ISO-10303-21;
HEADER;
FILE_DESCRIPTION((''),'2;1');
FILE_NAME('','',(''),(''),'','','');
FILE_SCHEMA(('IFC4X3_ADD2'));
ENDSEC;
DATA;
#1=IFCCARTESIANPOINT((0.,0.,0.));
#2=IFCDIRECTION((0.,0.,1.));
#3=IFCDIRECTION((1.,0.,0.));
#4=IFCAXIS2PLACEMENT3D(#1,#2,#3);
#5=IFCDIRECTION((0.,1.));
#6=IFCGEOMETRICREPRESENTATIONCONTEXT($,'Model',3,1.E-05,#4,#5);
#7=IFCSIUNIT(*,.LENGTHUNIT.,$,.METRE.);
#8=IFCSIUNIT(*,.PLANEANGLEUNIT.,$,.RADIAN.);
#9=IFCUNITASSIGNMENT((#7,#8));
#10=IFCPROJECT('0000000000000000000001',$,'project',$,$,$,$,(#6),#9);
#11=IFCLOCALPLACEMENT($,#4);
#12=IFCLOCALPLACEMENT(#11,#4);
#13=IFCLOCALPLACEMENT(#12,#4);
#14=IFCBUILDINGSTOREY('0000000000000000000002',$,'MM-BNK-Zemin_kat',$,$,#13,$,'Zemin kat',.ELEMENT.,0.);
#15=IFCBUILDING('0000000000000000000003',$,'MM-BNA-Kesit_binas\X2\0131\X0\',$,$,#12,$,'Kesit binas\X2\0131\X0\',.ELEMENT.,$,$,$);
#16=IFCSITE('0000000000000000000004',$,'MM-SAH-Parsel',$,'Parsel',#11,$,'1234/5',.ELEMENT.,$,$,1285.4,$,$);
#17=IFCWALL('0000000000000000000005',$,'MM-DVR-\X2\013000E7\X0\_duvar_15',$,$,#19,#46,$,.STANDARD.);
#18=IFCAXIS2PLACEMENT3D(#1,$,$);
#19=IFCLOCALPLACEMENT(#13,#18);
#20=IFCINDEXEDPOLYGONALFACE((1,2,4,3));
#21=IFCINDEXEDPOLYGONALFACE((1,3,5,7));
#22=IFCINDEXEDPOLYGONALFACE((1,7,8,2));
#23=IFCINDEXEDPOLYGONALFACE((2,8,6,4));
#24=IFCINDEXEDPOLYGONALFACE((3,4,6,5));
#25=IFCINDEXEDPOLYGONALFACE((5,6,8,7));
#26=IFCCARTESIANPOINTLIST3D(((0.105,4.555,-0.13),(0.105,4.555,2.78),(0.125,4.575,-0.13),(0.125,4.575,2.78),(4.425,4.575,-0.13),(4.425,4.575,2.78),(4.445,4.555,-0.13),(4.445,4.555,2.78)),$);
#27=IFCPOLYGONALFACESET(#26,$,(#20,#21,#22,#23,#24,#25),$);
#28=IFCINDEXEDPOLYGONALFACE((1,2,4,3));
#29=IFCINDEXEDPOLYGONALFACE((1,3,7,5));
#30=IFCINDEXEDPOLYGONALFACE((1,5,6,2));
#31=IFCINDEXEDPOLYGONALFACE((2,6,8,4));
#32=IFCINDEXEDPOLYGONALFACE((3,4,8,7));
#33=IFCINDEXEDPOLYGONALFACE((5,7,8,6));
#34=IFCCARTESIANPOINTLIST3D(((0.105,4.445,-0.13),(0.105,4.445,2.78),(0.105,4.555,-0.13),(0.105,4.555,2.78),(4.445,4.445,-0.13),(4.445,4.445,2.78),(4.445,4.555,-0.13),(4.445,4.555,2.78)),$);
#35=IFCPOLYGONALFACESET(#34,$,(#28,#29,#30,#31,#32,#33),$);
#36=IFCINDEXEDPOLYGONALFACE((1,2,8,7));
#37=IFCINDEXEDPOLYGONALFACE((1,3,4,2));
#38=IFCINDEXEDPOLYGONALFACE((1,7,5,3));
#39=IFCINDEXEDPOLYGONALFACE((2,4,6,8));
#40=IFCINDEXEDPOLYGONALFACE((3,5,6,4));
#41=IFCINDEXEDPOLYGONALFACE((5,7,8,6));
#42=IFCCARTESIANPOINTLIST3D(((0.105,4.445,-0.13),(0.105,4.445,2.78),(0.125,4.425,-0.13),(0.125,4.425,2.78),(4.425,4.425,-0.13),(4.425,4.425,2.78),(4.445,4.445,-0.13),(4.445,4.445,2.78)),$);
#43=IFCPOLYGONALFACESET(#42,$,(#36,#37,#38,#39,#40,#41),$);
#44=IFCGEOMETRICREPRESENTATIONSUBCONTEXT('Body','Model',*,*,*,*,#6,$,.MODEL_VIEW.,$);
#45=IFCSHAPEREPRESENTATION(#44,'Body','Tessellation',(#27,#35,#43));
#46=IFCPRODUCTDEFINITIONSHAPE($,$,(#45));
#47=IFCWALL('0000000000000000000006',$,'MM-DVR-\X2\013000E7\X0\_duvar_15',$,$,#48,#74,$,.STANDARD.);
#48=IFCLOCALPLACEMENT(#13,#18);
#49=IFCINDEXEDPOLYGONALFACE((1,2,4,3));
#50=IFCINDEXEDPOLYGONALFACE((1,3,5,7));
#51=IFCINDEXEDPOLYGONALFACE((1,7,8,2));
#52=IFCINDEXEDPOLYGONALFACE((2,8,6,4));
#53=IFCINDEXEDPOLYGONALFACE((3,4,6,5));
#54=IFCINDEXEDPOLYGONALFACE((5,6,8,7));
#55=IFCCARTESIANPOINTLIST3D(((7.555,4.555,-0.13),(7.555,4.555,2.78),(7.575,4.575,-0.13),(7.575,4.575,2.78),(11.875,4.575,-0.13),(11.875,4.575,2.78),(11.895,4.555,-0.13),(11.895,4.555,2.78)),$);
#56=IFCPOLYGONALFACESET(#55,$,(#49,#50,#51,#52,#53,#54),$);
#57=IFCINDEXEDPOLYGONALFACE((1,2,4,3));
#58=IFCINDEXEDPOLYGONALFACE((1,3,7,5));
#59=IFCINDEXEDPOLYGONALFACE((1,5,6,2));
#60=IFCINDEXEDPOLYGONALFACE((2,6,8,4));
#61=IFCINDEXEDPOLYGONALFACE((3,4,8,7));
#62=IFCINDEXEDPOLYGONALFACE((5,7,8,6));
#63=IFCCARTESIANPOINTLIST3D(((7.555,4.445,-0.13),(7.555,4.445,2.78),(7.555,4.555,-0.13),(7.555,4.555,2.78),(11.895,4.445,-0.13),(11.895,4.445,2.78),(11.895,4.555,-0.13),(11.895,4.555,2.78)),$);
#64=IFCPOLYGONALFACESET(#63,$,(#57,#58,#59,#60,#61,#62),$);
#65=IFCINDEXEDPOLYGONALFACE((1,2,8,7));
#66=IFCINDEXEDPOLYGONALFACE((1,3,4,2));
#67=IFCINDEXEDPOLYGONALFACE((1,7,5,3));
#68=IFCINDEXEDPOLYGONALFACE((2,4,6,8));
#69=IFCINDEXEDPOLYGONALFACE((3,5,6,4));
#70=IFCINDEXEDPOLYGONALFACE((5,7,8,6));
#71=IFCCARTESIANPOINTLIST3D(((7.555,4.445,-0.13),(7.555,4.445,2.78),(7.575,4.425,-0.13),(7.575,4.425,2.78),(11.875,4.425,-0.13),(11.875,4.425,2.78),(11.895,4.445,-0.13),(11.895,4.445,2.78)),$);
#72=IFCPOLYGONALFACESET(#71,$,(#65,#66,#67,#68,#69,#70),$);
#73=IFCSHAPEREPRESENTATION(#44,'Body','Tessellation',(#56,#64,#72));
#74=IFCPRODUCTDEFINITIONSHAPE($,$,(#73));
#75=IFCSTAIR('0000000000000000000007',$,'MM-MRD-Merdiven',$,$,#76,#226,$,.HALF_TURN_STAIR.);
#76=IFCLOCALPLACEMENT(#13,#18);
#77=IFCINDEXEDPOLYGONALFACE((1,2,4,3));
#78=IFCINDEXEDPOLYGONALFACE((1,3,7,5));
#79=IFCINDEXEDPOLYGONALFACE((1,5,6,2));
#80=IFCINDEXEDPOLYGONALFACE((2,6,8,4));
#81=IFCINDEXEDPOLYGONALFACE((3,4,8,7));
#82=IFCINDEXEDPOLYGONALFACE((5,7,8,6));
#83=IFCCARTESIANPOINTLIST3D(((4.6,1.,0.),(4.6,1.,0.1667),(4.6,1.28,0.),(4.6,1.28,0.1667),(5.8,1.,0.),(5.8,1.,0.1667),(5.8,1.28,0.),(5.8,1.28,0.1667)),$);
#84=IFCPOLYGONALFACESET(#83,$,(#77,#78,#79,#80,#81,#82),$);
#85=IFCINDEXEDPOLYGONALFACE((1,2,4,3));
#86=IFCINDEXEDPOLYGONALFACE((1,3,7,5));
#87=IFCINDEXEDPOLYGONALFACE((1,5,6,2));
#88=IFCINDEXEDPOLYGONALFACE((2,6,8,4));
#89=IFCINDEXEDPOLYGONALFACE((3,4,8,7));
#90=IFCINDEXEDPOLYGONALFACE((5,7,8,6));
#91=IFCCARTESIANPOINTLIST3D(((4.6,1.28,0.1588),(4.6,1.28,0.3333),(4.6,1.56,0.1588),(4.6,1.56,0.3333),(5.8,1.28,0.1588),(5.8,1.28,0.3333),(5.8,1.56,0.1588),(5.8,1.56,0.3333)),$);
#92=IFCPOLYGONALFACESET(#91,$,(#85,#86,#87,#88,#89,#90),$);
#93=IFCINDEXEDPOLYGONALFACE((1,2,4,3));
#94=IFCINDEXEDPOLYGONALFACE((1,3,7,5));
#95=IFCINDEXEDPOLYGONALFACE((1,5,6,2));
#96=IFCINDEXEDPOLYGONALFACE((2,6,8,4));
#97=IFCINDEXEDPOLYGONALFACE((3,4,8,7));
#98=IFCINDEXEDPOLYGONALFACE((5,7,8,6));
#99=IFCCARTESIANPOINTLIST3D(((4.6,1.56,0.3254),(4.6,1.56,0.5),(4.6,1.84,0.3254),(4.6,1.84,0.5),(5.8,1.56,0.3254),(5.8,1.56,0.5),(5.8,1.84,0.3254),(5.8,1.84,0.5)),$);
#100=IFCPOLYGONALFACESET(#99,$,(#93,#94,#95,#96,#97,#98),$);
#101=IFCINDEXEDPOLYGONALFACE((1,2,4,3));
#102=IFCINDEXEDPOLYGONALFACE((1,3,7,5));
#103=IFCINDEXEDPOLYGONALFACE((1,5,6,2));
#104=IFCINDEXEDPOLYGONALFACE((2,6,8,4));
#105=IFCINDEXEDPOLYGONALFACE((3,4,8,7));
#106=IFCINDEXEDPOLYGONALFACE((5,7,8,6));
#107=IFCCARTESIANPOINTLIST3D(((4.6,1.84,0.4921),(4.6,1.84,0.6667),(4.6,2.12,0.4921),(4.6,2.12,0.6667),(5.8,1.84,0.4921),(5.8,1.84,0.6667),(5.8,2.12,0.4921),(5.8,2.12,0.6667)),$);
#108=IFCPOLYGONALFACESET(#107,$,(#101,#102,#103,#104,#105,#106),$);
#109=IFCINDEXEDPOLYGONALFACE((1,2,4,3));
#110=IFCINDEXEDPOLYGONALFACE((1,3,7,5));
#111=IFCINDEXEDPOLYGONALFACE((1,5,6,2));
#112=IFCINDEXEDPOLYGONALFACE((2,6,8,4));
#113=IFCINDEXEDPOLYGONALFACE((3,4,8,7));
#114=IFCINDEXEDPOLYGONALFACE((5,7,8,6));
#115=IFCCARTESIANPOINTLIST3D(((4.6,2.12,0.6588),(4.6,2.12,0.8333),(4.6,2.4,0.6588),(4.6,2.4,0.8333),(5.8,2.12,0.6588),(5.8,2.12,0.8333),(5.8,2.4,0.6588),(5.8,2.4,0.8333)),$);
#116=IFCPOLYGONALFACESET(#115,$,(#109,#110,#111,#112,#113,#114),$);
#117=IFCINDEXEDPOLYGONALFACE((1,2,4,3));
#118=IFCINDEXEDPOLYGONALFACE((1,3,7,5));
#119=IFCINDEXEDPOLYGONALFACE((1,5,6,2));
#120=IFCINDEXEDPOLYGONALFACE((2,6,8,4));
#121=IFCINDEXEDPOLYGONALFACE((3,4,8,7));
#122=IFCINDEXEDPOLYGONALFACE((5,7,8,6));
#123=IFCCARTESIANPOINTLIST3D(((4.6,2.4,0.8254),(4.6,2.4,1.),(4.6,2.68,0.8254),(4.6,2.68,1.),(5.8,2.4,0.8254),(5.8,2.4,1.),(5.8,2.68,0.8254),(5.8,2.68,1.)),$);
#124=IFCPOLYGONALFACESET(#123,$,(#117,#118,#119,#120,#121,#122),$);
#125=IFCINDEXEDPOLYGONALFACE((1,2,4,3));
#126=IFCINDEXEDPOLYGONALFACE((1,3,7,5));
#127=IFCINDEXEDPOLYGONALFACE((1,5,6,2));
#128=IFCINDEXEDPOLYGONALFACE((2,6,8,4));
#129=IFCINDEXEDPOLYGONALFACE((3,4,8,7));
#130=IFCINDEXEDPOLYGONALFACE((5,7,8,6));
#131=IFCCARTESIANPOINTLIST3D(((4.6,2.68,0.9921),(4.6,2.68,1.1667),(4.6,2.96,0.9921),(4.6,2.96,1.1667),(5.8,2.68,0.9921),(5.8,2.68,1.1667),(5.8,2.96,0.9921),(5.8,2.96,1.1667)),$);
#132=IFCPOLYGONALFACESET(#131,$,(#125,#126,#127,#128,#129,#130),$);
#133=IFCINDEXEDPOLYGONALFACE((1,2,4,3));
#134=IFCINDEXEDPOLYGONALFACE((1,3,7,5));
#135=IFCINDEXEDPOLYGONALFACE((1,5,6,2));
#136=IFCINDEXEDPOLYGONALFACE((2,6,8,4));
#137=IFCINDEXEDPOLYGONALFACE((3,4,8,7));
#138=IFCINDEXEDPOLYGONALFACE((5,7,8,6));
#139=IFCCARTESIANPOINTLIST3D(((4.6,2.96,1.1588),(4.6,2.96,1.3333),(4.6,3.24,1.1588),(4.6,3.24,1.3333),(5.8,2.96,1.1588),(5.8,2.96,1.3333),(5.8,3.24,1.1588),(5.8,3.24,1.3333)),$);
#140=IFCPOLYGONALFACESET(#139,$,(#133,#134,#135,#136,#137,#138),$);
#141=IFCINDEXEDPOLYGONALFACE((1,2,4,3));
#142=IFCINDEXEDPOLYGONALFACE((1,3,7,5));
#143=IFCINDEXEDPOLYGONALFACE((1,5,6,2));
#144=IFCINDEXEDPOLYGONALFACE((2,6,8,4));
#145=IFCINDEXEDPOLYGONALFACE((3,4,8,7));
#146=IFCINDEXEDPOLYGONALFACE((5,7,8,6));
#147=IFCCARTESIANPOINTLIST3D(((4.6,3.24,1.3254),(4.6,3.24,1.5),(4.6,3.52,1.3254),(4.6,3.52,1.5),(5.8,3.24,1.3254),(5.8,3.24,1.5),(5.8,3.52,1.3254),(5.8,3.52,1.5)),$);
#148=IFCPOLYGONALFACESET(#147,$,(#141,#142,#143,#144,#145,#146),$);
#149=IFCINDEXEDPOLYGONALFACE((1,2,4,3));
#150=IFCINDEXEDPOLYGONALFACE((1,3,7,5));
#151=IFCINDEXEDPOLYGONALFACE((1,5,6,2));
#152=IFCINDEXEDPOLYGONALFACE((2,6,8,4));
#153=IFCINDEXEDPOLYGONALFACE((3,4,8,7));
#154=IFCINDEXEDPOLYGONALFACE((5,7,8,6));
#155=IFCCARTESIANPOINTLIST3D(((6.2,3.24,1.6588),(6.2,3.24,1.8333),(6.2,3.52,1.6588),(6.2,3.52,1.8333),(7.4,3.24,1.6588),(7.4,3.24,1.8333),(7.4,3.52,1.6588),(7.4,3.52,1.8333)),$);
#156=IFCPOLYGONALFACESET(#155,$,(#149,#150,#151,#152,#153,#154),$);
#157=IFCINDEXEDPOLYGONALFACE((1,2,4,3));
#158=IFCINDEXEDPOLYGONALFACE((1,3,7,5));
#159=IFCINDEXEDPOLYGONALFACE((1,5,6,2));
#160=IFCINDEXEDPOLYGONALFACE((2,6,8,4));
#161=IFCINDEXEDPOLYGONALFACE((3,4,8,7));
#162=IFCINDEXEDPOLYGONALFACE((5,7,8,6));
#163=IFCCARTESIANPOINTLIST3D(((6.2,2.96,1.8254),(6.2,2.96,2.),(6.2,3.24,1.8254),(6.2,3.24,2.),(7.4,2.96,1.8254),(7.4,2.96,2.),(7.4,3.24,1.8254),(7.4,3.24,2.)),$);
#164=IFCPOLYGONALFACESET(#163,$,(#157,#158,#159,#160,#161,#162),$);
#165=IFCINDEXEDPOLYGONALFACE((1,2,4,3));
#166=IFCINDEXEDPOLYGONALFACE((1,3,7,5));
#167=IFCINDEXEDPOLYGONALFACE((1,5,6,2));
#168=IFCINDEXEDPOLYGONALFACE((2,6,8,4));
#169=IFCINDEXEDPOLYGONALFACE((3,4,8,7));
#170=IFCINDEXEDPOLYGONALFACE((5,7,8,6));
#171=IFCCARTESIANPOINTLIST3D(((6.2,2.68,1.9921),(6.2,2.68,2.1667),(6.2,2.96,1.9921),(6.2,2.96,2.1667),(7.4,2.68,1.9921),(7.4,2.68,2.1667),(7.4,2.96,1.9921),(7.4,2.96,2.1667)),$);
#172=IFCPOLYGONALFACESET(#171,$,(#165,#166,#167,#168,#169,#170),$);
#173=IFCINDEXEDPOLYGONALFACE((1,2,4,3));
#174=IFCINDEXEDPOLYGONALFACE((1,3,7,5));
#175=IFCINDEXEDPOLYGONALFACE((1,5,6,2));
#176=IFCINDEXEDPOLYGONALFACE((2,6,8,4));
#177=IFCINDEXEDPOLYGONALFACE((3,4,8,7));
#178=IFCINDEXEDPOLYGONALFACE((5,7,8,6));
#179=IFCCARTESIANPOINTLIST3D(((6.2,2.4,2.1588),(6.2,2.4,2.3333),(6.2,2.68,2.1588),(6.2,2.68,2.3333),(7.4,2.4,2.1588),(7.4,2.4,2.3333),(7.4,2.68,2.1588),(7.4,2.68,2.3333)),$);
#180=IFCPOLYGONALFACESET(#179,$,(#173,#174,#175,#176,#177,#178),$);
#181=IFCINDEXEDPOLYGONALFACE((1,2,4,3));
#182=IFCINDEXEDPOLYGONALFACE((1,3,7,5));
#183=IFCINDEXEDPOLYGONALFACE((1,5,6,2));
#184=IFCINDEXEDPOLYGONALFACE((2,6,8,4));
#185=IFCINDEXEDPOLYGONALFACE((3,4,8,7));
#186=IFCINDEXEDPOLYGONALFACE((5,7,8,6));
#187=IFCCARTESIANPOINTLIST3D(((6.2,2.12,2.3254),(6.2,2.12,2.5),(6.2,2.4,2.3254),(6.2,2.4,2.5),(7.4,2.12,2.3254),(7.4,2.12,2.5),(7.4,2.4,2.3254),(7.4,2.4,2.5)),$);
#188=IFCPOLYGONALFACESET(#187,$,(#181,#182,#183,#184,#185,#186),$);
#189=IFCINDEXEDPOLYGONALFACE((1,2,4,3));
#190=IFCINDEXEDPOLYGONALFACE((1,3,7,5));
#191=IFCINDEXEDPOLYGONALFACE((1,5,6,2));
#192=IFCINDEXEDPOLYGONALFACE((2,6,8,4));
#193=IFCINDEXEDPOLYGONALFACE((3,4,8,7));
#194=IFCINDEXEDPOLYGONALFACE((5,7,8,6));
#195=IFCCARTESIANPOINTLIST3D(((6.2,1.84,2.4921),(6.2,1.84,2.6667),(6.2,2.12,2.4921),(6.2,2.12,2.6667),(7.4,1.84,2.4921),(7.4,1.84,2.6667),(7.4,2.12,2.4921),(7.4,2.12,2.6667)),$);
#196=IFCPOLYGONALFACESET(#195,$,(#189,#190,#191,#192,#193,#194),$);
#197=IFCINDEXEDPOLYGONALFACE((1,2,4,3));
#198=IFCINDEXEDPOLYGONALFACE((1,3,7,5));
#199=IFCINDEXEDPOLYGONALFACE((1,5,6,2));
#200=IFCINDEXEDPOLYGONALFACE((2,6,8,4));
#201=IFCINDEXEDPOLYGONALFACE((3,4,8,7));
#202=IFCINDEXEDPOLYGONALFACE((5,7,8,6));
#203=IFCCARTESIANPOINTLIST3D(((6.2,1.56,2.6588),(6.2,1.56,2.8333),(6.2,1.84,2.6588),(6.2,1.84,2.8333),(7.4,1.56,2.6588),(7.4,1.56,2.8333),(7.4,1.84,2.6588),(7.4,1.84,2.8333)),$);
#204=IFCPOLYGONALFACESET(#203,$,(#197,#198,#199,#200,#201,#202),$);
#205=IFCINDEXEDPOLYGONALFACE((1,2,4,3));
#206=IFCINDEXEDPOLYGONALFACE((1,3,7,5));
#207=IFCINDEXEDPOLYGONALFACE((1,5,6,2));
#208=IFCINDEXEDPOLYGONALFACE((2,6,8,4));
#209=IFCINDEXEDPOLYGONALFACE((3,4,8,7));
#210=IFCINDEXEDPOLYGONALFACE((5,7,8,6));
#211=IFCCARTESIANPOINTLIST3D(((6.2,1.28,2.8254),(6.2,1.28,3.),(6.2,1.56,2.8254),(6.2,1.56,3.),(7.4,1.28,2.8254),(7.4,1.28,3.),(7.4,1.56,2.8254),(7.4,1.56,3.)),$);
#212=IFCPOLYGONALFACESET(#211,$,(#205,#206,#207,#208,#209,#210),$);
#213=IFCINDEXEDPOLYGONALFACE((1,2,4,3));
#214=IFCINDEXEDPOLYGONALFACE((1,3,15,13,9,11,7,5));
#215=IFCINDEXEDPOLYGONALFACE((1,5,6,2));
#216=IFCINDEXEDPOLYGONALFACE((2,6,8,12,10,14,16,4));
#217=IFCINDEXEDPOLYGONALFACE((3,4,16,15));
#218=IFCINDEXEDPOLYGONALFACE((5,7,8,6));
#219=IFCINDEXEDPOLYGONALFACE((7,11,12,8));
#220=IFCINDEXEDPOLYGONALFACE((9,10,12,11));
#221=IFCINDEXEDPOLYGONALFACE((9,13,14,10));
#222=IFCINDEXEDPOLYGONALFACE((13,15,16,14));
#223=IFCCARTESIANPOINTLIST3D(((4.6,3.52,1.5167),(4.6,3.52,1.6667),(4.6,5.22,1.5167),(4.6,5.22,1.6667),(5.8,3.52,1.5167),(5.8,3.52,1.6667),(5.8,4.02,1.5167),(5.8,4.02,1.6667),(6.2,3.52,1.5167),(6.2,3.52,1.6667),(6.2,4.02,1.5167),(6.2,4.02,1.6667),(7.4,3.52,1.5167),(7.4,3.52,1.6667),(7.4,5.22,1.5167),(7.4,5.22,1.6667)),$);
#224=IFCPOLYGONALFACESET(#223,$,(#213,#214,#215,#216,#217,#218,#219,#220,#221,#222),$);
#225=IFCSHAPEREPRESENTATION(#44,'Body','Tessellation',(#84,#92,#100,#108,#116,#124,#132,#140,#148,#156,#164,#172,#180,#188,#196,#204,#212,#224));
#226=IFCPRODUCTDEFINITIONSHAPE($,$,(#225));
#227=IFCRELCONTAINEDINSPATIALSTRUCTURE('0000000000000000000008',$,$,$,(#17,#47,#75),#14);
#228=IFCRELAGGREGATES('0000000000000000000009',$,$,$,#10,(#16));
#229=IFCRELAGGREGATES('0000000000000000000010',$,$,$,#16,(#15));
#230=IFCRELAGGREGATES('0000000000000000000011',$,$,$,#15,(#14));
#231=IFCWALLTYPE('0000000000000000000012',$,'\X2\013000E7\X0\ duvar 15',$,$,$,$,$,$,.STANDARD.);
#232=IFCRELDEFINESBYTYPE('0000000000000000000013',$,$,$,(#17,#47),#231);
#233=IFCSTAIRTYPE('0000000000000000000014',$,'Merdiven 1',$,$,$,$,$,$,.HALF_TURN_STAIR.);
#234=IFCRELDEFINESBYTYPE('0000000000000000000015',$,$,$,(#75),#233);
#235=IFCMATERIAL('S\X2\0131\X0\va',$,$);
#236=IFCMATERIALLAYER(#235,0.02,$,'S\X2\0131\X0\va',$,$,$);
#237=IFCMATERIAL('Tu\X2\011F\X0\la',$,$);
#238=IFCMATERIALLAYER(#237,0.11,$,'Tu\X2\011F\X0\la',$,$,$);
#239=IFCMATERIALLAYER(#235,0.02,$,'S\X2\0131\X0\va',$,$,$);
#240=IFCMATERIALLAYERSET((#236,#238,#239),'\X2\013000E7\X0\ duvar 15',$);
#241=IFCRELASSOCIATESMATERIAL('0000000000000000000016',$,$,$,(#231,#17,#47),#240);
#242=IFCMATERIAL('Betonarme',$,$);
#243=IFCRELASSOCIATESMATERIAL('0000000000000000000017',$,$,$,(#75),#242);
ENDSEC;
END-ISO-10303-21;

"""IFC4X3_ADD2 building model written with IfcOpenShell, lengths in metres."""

from ifc_helpers import new_model, si_unit, direction, frame, origin, origin_with_axes, place, context, subcontext, project, spatial, polyline, outline, extrude, material, layer, layer_set, type_object, element, save


model = new_model("IFC4X3_ADD2")

# Units and contexts
model_context = context("Model", 3, precision=1e-05, world=origin_with_axes(), true_north=direction((0.0, 1.0)))
body_context = subcontext(model_context, "Body", "Model", "MODEL_VIEW")
ifc_project = project(units=[si_unit("LENGTHUNIT", "METRE"), si_unit("PLANEANGLEUNIT", "RADIAN")], contexts=[model_context])

# Site, building, storey
site_placement = place(None, origin_with_axes())
site = spatial("IfcSite", under=ifc_project, at=site_placement, Name="MM-SAH-Parsel", ObjectType="Parsel", LongName="1234/5", CompositionType="ELEMENT", RefElevation=1285.4)
building_placement = place(site_placement, origin_with_axes())
building = spatial("IfcBuilding", under=site, at=building_placement, Name="MM-BNA-Kesit_binası", LongName="Kesit binası", CompositionType="ELEMENT")
storey_placement = place(building_placement, origin_with_axes())
storey = spatial("IfcBuildingStorey", under=building, at=storey_placement, Name="MM-BNK-Zemin_kat", LongName="Zemin kat", CompositionType="ELEMENT", Elevation=0.0)

# Shared definitions
ifc_material_1 = material(Name="Betonarme")

# Shared definitions
ifc_material_2 = material(Name="Tuğla")

# Shared definitions
ifc_material_3 = material(Name="Sıva")
ifc_layer_1 = layer(ifc_material_3, 0.02, Name="Sıva")
ifc_layer_2 = layer(ifc_material_2, 0.11, Name="Tuğla")
ifc_layer_3 = layer(ifc_material_3, 0.02, Name="Sıva")
ifc_layer_set_1 = layer_set([ifc_layer_1, ifc_layer_2, ifc_layer_3], Name="İç duvar 15")
wall_type_1 = type_object("IfcWallType", Name="İç duvar 15", PredefinedType="STANDARD", material=ifc_layer_set_1)

# Walls
wall_1_placement = place(storey_placement, origin_with_axes())
element("IfcWall", 1, at=wall_1_placement, inside=storey, type_object=wall_type_1, material=ifc_layer_set_1, Name="MM-DVR-İç_duvar_15", PredefinedType="STANDARD", context=body_context, shape_type="SweptSolid", body=[
    extrude(outline(polyline([(0.125, 4.575), (4.425, 4.575), (4.445, 4.555), (0.105, 4.555), (0.125, 4.575)])), frame((0.0, 0.0, -0.13)), (0.0, 0.0, 1.0), 2.91),
    extrude(outline(polyline([(0.105, 4.555), (4.445, 4.555), (4.445, 4.445), (0.105, 4.445), (0.105, 4.555)])), frame((0.0, 0.0, -0.13)), (0.0, 0.0, 1.0), 2.91),
    extrude(outline(polyline([(0.105, 4.445), (4.445, 4.445), (4.425, 4.425), (0.125, 4.425), (0.105, 4.445)])), frame((0.0, 0.0, -0.13)), (0.0, 0.0, 1.0), 2.91),
])
wall_2_placement = place(storey_placement, origin_with_axes())
element("IfcWall", 2, at=wall_2_placement, inside=storey, type_object=wall_type_1, material=ifc_layer_set_1, Name="MM-DVR-İç_duvar_15", PredefinedType="STANDARD", context=body_context, shape_type="SweptSolid", body=[
    extrude(outline(polyline([(7.575, 4.575), (11.875, 4.575), (11.895, 4.555), (7.555, 4.555), (7.575, 4.575)])), frame((0.0, 0.0, -0.13)), (0.0, 0.0, 1.0), 2.91),
    extrude(outline(polyline([(7.555, 4.555), (11.895, 4.555), (11.895, 4.445), (7.555, 4.445), (7.555, 4.555)])), frame((0.0, 0.0, -0.13)), (0.0, 0.0, 1.0), 2.91),
    extrude(outline(polyline([(7.555, 4.445), (11.895, 4.445), (11.875, 4.425), (7.575, 4.425), (7.555, 4.445)])), frame((0.0, 0.0, -0.13)), (0.0, 0.0, 1.0), 2.91),
])

# Stair
stair_type = type_object("IfcStairType", Name="Merdiven 1", PredefinedType="HALF_TURN_STAIR")
stair_placement = place(storey_placement, origin_with_axes())
element("IfcStair", 3, at=stair_placement, inside=storey, type_object=stair_type, material=ifc_material_1, Name="MM-MRD-Merdiven", PredefinedType="HALF_TURN_STAIR", context=body_context, shape_type="SweptSolid", body=[
    extrude(outline(polyline([(5.8, 1.0), (5.8, 1.28), (4.6, 1.28), (4.6, 1.0), (5.8, 1.0)])), origin(), (0.0, 0.0, 1.0), 0.1667),
    extrude(outline(polyline([(5.8, 1.28), (5.8, 1.56), (4.6, 1.56), (4.6, 1.28), (5.8, 1.28)])), frame((0.0, 0.0, 0.1588)), (0.0, 0.0, 1.0), 0.1746),
    extrude(outline(polyline([(5.8, 1.56), (5.8, 1.84), (4.6, 1.84), (4.6, 1.56), (5.8, 1.56)])), frame((0.0, 0.0, 0.3254)), (0.0, 0.0, 1.0), 0.1746),
    extrude(outline(polyline([(5.8, 1.84), (5.8, 2.12), (4.6, 2.12), (4.6, 1.84), (5.8, 1.84)])), frame((0.0, 0.0, 0.4921)), (0.0, 0.0, 1.0), 0.1746),
    extrude(outline(polyline([(5.8, 2.12), (5.8, 2.4), (4.6, 2.4), (4.6, 2.12), (5.8, 2.12)])), frame((0.0, 0.0, 0.6588)), (0.0, 0.0, 1.0), 0.1746),
    extrude(outline(polyline([(5.8, 2.4), (5.8, 2.68), (4.6, 2.68), (4.6, 2.4), (5.8, 2.4)])), frame((0.0, 0.0, 0.8254)), (0.0, 0.0, 1.0), 0.1746),
    extrude(outline(polyline([(5.8, 2.68), (5.8, 2.96), (4.6, 2.96), (4.6, 2.68), (5.8, 2.68)])), frame((0.0, 0.0, 0.9921)), (0.0, 0.0, 1.0), 0.1746),
    extrude(outline(polyline([(5.8, 2.96), (5.8, 3.24), (4.6, 3.24), (4.6, 2.96), (5.8, 2.96)])), frame((0.0, 0.0, 1.1588)), (0.0, 0.0, 1.0), 0.1746),
    extrude(outline(polyline([(5.8, 3.24), (5.8, 3.52), (4.6, 3.52), (4.6, 3.24), (5.8, 3.24)])), frame((0.0, 0.0, 1.3254)), (0.0, 0.0, 1.0), 0.1746),
    extrude(outline(polyline([(6.2, 3.52), (6.2, 3.24), (7.4, 3.24), (7.4, 3.52), (6.2, 3.52)])), frame((0.0, 0.0, 1.6588)), (0.0, 0.0, 1.0), 0.1746),
    extrude(outline(polyline([(6.2, 3.24), (6.2, 2.96), (7.4, 2.96), (7.4, 3.24), (6.2, 3.24)])), frame((0.0, 0.0, 1.8254)), (0.0, 0.0, 1.0), 0.1746),
    extrude(outline(polyline([(6.2, 2.96), (6.2, 2.68), (7.4, 2.68), (7.4, 2.96), (6.2, 2.96)])), frame((0.0, 0.0, 1.9921)), (0.0, 0.0, 1.0), 0.1746),
    extrude(outline(polyline([(6.2, 2.68), (6.2, 2.4), (7.4, 2.4), (7.4, 2.68), (6.2, 2.68)])), frame((0.0, 0.0, 2.1588)), (0.0, 0.0, 1.0), 0.1746),
    extrude(outline(polyline([(6.2, 2.4), (6.2, 2.12), (7.4, 2.12), (7.4, 2.4), (6.2, 2.4)])), frame((0.0, 0.0, 2.3254)), (0.0, 0.0, 1.0), 0.1746),
    extrude(outline(polyline([(6.2, 2.12), (6.2, 1.84), (7.4, 1.84), (7.4, 2.12), (6.2, 2.12)])), frame((0.0, 0.0, 2.4921)), (0.0, 0.0, 1.0), 0.1746),
    extrude(outline(polyline([(6.2, 1.84), (6.2, 1.56), (7.4, 1.56), (7.4, 1.84), (6.2, 1.84)])), frame((0.0, 0.0, 2.6588)), (0.0, 0.0, 1.0), 0.1746),
    extrude(outline(polyline([(6.2, 1.56), (6.2, 1.28), (7.4, 1.28), (7.4, 1.56), (6.2, 1.56)])), frame((0.0, 0.0, 2.8254)), (0.0, 0.0, 1.0), 0.1746),
    extrude(outline(polyline([(4.6, 3.52), (4.6, 5.22), (7.4, 5.22), (7.4, 3.52), (6.2, 3.52), (6.2, 4.02), (5.8, 4.02), (5.8, 3.52), (4.6, 3.52)])), frame((0.0, 0.0, 1.5167)), (0.0, 0.0, 1.0), 0.15),
])

save(model, "model.ifc")
